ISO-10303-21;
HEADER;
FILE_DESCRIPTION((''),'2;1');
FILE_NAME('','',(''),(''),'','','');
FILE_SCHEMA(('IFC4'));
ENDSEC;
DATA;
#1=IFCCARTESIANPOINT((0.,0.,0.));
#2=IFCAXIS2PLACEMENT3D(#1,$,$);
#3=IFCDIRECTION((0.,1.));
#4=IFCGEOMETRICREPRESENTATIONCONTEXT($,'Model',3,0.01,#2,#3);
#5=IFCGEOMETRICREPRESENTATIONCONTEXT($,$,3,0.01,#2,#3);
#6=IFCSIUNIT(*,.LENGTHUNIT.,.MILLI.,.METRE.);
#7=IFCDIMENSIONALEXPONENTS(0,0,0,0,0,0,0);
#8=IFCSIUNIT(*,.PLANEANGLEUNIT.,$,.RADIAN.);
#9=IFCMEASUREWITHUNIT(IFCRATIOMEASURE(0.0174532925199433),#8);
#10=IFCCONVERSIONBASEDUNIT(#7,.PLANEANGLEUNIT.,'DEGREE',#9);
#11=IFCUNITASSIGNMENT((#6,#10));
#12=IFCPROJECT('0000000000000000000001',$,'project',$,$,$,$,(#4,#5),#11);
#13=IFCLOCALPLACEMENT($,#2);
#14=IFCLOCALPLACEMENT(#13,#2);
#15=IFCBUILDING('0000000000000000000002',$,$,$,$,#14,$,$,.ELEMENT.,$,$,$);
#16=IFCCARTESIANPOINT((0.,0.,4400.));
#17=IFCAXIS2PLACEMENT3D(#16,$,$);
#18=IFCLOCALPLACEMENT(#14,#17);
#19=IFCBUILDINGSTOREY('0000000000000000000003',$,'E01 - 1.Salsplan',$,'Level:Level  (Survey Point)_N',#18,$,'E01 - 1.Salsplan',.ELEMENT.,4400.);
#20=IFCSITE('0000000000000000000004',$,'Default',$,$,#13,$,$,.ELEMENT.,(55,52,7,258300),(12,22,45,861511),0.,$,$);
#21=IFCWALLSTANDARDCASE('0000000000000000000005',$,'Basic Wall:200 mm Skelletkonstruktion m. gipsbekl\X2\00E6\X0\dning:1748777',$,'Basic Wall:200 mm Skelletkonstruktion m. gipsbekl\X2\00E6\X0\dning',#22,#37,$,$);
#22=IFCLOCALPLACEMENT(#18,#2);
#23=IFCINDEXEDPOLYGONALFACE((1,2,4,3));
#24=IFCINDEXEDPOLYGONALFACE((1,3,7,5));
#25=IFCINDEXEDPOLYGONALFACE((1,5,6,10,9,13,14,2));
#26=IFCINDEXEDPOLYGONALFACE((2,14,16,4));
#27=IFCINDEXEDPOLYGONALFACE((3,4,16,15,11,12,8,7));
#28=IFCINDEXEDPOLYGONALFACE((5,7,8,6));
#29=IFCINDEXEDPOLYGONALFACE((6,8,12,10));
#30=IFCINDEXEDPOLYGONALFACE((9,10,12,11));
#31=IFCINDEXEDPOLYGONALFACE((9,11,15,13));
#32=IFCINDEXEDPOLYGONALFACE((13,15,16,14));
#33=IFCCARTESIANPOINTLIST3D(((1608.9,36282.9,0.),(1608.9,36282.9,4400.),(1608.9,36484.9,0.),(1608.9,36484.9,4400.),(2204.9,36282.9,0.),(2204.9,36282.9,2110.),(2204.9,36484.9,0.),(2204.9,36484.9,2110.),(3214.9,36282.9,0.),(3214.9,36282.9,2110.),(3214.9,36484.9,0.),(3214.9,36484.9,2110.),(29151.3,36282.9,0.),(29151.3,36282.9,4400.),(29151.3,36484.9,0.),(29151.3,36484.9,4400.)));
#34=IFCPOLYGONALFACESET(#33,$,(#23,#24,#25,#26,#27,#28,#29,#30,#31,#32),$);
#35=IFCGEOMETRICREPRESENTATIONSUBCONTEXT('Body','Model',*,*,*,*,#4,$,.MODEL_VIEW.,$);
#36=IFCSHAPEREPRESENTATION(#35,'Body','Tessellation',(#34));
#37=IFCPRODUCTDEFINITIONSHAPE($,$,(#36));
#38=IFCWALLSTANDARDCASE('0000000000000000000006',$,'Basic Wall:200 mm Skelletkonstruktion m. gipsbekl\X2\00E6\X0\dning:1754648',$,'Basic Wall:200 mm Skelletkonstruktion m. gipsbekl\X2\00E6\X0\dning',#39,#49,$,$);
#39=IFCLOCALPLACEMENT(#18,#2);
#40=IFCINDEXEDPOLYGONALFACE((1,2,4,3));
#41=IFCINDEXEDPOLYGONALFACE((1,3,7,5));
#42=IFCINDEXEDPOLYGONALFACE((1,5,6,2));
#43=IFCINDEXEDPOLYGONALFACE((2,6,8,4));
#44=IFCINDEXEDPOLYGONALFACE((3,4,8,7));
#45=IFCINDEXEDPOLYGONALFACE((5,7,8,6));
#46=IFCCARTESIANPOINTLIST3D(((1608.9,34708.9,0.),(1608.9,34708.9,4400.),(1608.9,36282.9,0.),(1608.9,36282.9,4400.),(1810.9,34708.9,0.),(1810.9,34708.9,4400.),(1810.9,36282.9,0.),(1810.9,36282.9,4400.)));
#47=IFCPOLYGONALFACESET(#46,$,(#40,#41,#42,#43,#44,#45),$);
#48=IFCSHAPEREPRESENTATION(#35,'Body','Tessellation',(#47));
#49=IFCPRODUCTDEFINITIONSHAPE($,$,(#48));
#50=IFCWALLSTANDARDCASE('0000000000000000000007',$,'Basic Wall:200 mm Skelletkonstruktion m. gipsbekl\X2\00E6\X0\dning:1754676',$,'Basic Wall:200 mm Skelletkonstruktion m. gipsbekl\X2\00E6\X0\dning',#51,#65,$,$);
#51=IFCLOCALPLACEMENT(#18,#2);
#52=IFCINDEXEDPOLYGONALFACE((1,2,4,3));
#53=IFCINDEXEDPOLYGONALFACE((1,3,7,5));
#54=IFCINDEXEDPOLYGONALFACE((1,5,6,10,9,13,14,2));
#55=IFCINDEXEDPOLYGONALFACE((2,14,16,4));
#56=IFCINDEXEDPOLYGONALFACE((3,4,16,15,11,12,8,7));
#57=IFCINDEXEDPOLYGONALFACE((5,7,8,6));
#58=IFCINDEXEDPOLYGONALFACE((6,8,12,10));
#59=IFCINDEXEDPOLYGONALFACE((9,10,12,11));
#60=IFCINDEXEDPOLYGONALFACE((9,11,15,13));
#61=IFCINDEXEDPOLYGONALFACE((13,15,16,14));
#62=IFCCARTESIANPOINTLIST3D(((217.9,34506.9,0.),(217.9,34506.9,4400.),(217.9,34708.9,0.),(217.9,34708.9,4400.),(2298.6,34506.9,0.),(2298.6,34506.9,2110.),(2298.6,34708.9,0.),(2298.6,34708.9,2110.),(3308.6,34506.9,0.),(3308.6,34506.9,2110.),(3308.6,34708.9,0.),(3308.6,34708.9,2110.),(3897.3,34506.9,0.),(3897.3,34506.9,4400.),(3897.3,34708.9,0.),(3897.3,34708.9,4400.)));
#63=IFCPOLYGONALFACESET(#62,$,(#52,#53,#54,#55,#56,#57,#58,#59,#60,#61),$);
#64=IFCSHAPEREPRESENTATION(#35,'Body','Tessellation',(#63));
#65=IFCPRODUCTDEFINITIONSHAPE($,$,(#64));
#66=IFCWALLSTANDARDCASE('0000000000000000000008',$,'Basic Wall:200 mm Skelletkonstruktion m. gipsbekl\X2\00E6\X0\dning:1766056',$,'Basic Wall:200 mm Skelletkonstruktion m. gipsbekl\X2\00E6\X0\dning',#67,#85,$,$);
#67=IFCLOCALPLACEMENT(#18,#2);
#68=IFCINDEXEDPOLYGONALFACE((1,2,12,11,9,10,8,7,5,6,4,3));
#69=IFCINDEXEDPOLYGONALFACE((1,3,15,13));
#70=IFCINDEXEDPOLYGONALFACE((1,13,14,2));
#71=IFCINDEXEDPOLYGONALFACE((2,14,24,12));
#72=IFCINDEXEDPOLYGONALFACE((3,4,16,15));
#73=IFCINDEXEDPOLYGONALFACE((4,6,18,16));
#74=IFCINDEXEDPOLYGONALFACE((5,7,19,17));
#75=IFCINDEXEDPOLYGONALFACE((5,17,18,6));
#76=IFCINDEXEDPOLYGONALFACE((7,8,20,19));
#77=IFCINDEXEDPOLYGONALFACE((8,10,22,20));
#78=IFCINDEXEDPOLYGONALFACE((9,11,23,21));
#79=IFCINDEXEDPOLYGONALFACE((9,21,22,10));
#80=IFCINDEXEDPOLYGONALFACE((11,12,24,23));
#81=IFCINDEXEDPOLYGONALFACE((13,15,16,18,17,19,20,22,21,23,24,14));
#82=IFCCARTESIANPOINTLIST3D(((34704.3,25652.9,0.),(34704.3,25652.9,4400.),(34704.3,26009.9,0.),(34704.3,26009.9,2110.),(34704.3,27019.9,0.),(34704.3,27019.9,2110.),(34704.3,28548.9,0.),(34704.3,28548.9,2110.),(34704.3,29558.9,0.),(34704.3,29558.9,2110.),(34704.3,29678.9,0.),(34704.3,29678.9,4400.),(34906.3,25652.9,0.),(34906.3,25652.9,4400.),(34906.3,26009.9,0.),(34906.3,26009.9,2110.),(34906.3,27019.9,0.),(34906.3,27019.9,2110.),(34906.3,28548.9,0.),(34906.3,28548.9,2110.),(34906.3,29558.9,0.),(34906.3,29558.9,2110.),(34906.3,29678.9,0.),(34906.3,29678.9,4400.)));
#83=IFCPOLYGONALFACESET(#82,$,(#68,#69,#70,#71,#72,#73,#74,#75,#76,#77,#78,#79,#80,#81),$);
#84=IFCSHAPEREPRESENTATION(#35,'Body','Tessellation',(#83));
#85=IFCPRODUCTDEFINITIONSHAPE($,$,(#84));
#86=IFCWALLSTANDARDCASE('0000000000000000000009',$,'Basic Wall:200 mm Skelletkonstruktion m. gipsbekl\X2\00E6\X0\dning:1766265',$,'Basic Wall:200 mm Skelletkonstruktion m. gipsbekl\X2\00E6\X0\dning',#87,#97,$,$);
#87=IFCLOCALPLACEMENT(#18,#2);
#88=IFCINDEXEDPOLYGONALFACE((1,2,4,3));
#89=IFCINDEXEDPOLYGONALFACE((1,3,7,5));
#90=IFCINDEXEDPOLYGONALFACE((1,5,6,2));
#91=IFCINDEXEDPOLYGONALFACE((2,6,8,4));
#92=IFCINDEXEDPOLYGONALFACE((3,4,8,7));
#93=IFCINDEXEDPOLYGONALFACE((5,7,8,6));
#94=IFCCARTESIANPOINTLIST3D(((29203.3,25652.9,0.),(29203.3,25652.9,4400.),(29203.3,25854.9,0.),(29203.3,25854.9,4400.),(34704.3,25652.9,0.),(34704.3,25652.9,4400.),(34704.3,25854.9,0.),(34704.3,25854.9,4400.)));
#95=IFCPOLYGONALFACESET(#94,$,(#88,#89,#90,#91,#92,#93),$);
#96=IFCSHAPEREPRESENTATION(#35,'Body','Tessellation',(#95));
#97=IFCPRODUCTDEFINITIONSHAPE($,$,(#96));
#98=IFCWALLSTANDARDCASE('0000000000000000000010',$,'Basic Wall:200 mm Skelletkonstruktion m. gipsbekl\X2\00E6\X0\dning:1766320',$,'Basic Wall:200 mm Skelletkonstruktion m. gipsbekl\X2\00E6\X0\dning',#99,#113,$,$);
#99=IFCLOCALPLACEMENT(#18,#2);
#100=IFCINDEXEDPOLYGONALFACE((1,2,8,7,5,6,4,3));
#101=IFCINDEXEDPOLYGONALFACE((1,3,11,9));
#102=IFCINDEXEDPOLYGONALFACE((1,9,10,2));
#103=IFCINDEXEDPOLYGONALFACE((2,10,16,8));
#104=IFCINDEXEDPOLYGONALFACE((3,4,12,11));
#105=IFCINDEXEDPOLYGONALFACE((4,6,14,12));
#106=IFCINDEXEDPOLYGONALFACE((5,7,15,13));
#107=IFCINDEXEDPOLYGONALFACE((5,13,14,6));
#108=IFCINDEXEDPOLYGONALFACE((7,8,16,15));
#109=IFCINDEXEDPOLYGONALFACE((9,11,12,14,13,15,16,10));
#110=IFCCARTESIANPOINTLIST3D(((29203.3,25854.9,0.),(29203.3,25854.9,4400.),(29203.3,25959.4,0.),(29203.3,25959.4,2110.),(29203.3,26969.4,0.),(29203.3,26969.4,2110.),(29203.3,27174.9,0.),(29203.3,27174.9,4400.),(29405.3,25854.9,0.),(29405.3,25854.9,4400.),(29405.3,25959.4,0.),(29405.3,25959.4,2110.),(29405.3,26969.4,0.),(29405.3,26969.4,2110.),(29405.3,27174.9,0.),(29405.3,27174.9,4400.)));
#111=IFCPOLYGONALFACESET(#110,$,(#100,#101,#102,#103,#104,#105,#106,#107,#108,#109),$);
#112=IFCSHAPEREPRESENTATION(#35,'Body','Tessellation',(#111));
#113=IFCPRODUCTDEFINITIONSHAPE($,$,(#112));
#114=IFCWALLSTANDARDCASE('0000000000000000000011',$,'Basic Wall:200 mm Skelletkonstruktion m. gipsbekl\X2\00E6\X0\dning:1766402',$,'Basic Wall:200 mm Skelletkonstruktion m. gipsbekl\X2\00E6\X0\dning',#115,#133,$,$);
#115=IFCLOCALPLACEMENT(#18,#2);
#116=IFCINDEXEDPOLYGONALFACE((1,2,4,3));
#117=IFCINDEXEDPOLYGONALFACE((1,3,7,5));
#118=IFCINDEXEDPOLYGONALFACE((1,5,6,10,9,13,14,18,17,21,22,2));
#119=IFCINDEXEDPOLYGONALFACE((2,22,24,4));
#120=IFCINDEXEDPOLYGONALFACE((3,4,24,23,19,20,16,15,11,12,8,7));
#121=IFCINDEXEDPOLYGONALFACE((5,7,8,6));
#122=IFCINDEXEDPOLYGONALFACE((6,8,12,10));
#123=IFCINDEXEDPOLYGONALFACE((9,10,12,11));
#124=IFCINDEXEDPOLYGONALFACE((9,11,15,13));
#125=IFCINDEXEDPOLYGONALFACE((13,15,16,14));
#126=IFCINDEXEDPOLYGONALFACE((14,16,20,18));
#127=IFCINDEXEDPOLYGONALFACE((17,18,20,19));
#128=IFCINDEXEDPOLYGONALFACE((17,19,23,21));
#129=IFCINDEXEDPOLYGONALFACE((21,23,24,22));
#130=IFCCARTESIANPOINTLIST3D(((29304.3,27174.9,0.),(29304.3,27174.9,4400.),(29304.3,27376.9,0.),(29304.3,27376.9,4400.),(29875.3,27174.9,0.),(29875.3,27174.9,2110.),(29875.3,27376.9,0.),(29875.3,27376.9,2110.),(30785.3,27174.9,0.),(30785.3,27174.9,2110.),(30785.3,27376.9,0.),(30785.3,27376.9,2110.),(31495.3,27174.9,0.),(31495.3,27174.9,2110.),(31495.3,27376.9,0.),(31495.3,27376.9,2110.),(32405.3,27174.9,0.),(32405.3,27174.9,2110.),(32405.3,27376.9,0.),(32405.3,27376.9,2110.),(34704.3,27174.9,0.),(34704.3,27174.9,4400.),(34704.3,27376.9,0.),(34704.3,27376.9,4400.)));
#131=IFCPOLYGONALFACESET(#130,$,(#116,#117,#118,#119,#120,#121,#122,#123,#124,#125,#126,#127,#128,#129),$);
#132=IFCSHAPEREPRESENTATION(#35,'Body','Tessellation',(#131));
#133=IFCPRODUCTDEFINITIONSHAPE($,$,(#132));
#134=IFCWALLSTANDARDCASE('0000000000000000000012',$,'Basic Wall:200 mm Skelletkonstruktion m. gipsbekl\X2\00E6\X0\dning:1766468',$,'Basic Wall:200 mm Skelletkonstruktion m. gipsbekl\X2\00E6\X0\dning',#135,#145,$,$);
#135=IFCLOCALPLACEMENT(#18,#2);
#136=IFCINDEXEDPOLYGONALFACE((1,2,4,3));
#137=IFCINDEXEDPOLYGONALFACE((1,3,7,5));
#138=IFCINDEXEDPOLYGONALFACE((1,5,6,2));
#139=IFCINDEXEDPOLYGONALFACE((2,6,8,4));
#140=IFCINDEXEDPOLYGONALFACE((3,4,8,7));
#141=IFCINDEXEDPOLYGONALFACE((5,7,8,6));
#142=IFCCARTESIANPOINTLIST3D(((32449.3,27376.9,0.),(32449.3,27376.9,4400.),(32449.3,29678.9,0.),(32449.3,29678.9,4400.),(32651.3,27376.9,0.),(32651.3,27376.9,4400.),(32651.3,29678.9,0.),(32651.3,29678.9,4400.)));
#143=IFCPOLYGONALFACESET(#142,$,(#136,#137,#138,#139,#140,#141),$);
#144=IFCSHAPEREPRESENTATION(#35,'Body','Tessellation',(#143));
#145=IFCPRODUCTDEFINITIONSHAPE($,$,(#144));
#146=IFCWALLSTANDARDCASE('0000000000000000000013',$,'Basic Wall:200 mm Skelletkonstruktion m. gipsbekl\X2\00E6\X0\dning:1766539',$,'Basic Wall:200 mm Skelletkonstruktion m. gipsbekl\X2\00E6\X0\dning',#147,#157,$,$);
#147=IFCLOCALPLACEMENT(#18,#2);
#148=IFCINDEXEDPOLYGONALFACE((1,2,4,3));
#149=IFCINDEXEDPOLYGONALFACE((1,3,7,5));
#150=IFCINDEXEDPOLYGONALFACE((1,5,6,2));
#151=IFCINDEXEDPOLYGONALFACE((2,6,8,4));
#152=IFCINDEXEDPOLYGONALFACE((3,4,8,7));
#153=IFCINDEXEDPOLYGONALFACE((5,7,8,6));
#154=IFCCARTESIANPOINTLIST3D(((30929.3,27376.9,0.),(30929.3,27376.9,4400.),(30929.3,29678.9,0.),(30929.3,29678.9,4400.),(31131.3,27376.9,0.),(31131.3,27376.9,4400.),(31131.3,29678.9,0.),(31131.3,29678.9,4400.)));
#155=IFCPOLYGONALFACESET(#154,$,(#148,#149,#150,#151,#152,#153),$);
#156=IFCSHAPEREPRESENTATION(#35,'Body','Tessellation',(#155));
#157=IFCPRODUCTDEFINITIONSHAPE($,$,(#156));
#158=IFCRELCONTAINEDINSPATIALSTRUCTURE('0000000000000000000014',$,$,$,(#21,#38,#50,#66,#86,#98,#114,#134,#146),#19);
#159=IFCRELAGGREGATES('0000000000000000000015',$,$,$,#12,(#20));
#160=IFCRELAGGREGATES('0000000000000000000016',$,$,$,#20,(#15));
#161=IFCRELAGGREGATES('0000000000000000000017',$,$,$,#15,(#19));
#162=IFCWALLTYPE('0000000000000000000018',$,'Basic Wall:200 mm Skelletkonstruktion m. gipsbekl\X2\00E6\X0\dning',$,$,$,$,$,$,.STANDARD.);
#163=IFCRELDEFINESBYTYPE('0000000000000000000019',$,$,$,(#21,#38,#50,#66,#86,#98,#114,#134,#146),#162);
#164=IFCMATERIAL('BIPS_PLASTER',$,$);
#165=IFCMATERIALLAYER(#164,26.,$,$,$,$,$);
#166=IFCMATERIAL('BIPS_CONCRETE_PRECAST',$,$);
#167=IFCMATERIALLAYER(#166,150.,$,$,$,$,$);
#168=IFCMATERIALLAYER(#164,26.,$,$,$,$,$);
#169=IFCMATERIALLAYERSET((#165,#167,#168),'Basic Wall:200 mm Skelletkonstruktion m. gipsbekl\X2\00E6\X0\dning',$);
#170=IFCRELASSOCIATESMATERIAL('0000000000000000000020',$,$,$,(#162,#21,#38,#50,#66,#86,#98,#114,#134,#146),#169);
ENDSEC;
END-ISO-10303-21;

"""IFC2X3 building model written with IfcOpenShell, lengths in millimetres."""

from ifc_helpers import new_model, entity, si_unit, converted_unit, direction, frame, frame_2d, origin, place, context, subcontext, project, spatial, rectangle, extrude, material, layer, layer_set, layer_usage, type_object, element, save


model = new_model("IFC2X3")

# Units and contexts
model_context = context("Model", 3, precision=0.01, world=origin(), true_north=direction((0.0, 1.0)))
context_of_model = context(None, 3, precision=0.01, world=origin(), true_north=direction((0.0, 1.0)))
body_context = subcontext(model_context, "Body", "Model", "MODEL_VIEW")
ifc_project = project(units=[si_unit("LENGTHUNIT", "METRE", prefix="MILLI"), converted_unit("PLANEANGLEUNIT", "DEGREE", entity("IfcRatioMeasure", 0.0174532925199433), si_unit("PLANEANGLEUNIT", "RADIAN"), dimensions=[0, 0, 0, 0, 0, 0, 0])], contexts=[model_context, context_of_model])

# Site, building, storey
site_placement = place(None, origin())
site = spatial("IfcSite", under=ifc_project, at=site_placement, Name="Default", CompositionType="ELEMENT", RefLatitude=(55, 52, 7, 258300), RefLongitude=(12, 22, 45, 861511), RefElevation=0.0)
building_placement = place(site_placement, origin())
building = spatial("IfcBuilding", under=site, at=building_placement, CompositionType="ELEMENT")
storey_placement = place(building_placement, frame((0.0, 0.0, 4400.0)))
storey = spatial("IfcBuildingStorey", under=building, at=storey_placement, Name="E01 - 1.Salsplan", ObjectType="Level:Level  (Survey Point)_N", LongName="E01 - 1.Salsplan", CompositionType="ELEMENT", Elevation=4400.0)

# Shared definitions
ifc_material_1 = material(Name="BIPS_CONCRETE_PRECAST")

# Wall, opening
ifc_material_2 = material(Name="BIPS_PLASTER")
ifc_layer_1 = layer(ifc_material_2, 26.0)
ifc_layer_2 = layer(ifc_material_1, 150.0)
ifc_layer_3 = layer(ifc_material_2, 26.0)
ifc_layer_set_1 = layer_set([ifc_layer_1, ifc_layer_2, ifc_layer_3], Name="Basic Wall:200 mm Skelletkonstruktion m. gipsbeklædning")
ifc_layer_usage_1 = layer_usage(ifc_layer_set_1, "AXIS2", "NEGATIVE", 101.0)
wall_type_1 = type_object("IfcWallType", Name="Basic Wall:200 mm Skelletkonstruktion m. gipsbeklædning", PredefinedType="STANDARD", material=ifc_layer_set_1)
wall_1_placement = place(storey_placement, frame((29151.3, 36383.9, 0.0), z_axis=(0.0, 0.0, 1.0), x_axis=(-1.0, 0.0, 0.0)))
wall_1 = element("IfcWallStandardCase", 1, at=wall_1_placement, inside=storey, type_object=wall_type_1, material=ifc_layer_usage_1, Name="Basic Wall:200 mm Skelletkonstruktion m. gipsbeklædning:1748777", ObjectType="Basic Wall:200 mm Skelletkonstruktion m. gipsbeklædning", context=body_context, shape_type="SweptSolid", body=[
    extrude(rectangle(XDim=27542.4, YDim=202.0, at=frame_2d((13771.2, 0.0), x_axis=(-1.0, 0.0))), origin(), (0.0, 0.0, 1.0), 4400.0),
])
opening_1_placement = place(wall_1_placement, frame((26946.4, 101.0, 0.0)))
element("IfcOpeningElement", 2, at=opening_1_placement, cuts=wall_1, ObjectType="Opening", context=body_context, shape_type="SweptSolid", body=[
    extrude(rectangle(XDim=2110.0, YDim=1010.0, at=frame_2d((1055.0, 505.0), x_axis=(1.0, 0.0))), frame((0.0, 0.0, 0.0), z_axis=(0.0, -1.0, 0.0), x_axis=(0.0, 0.0, 1.0)), (0.0, 0.0, 1.0), 202.0),
])

# Wall
ifc_layer_usage_2 = layer_usage(ifc_layer_set_1, "AXIS2", "NEGATIVE", 101.0)
wall_2_placement = place(storey_placement, frame((1709.9, 36282.9, 0.0), z_axis=(0.0, 0.0, 1.0), x_axis=(0.0, -1.0, 0.0)))
element("IfcWallStandardCase", 3, at=wall_2_placement, inside=storey, type_object=wall_type_1, material=ifc_layer_usage_2, Name="Basic Wall:200 mm Skelletkonstruktion m. gipsbeklædning:1754648", ObjectType="Basic Wall:200 mm Skelletkonstruktion m. gipsbeklædning", context=body_context, shape_type="SweptSolid", body=[
    extrude(rectangle(XDim=1574.0, YDim=202.0, at=frame_2d((787.0, 0.0), x_axis=(-1.0, 0.0))), origin(), (0.0, 0.0, 1.0), 4400.0),
])

# Wall, opening
ifc_layer_usage_3 = layer_usage(ifc_layer_set_1, "AXIS2", "NEGATIVE", 101.0)
wall_3_placement = place(storey_placement, frame((217.9, 34607.9, 0.0)))
wall_3 = element("IfcWallStandardCase", 4, at=wall_3_placement, inside=storey, type_object=wall_type_1, material=ifc_layer_usage_3, Name="Basic Wall:200 mm Skelletkonstruktion m. gipsbeklædning:1754676", ObjectType="Basic Wall:200 mm Skelletkonstruktion m. gipsbeklædning", context=body_context, shape_type="SweptSolid", body=[
    extrude(rectangle(XDim=3679.4, YDim=202.0, at=frame_2d((1839.7, 0.0), x_axis=(-1.0, 0.0))), origin(), (0.0, 0.0, 1.0), 4400.0),
])
opening_2_placement = place(wall_3_placement, frame((3090.7, 101.0, 0.0)))
element("IfcOpeningElement", 5, at=opening_2_placement, cuts=wall_3, ObjectType="Opening", context=body_context, shape_type="SweptSolid", body=[
    extrude(rectangle(XDim=2110.0, YDim=1010.0, at=frame_2d((1055.0, 505.0), x_axis=(1.0, 0.0))), frame((0.0, 0.0, 0.0), z_axis=(0.0, -1.0, 0.0), x_axis=(0.0, 0.0, 1.0)), (0.0, 0.0, 1.0), 202.0),
])

# Wall, openings
ifc_layer_usage_4 = layer_usage(ifc_layer_set_1, "AXIS2", "NEGATIVE", 101.0)
wall_4_placement = place(storey_placement, frame((34805.3, 29678.9, 0.0), z_axis=(0.0, 0.0, 1.0), x_axis=(0.0, -1.0, 0.0)))
wall_4 = element("IfcWallStandardCase", 6, at=wall_4_placement, inside=storey, type_object=wall_type_1, material=ifc_layer_usage_4, Name="Basic Wall:200 mm Skelletkonstruktion m. gipsbeklædning:1766056", ObjectType="Basic Wall:200 mm Skelletkonstruktion m. gipsbeklædning", context=body_context, shape_type="SweptSolid", body=[
    extrude(rectangle(XDim=4026.0, YDim=202.0, at=frame_2d((2013.0, 0.0), x_axis=(-1.0, 0.0))), origin(), (0.0, 0.0, 1.0), 4400.0),
])
opening_3_placement = place(wall_4_placement, frame((1130.0, 101.0, 0.0)))
element("IfcOpeningElement", 7, at=opening_3_placement, cuts=wall_4, ObjectType="Opening", context=body_context, shape_type="SweptSolid", body=[
    extrude(rectangle(XDim=2110.0, YDim=1010.0, at=frame_2d((1055.0, 505.0), x_axis=(1.0, 0.0))), frame((0.0, 0.0, 0.0), z_axis=(0.0, -1.0, 0.0), x_axis=(0.0, 0.0, 1.0)), (0.0, 0.0, 1.0), 202.0),
])
opening_4_placement = place(wall_4_placement, frame((3669.0, 101.0, 0.0)))
element("IfcOpeningElement", 8, at=opening_4_placement, cuts=wall_4, ObjectType="Opening", context=body_context, shape_type="SweptSolid", body=[
    extrude(rectangle(XDim=2110.0, YDim=1010.0, at=frame_2d((1055.0, 505.0), x_axis=(1.0, 0.0))), frame((0.0, 0.0, 0.0), z_axis=(0.0, -1.0, 0.0), x_axis=(0.0, 0.0, 1.0)), (0.0, 0.0, 1.0), 202.0),
])

# Wall
ifc_layer_usage_5 = layer_usage(ifc_layer_set_1, "AXIS2", "NEGATIVE", 101.0)
wall_5_placement = place(storey_placement, frame((34704.3, 25753.9, 0.0), z_axis=(0.0, 0.0, 1.0), x_axis=(-1.0, 0.0, 0.0)))
element("IfcWallStandardCase", 9, at=wall_5_placement, inside=storey, type_object=wall_type_1, material=ifc_layer_usage_5, Name="Basic Wall:200 mm Skelletkonstruktion m. gipsbeklædning:1766265", ObjectType="Basic Wall:200 mm Skelletkonstruktion m. gipsbeklædning", context=body_context, shape_type="SweptSolid", body=[
    extrude(rectangle(XDim=5501.0, YDim=202.0, at=frame_2d((2750.5, 0.0), x_axis=(-1.0, 0.0))), origin(), (0.0, 0.0, 1.0), 4400.0),
])

# Wall, opening
ifc_layer_usage_6 = layer_usage(ifc_layer_set_1, "AXIS2", "NEGATIVE", 101.0)
wall_6_placement = place(storey_placement, frame((29304.3, 25854.9, 0.0), z_axis=(0.0, 0.0, 1.0), x_axis=(0.0, 1.0, 0.0)))
wall_6 = element("IfcWallStandardCase", 10, at=wall_6_placement, inside=storey, type_object=wall_type_1, material=ifc_layer_usage_6, Name="Basic Wall:200 mm Skelletkonstruktion m. gipsbeklædning:1766320", ObjectType="Basic Wall:200 mm Skelletkonstruktion m. gipsbeklædning", context=body_context, shape_type="SweptSolid", body=[
    extrude(rectangle(XDim=1320.0, YDim=202.0, at=frame_2d((660.0, 0.0), x_axis=(-1.0, 0.0))), origin(), (0.0, 0.0, 1.0), 4400.0),
])
opening_5_placement = place(wall_6_placement, frame((1114.5, 101.0, 0.0)))
element("IfcOpeningElement", 11, at=opening_5_placement, cuts=wall_6, ObjectType="Opening", context=body_context, shape_type="SweptSolid", body=[
    extrude(rectangle(XDim=2110.0, YDim=1010.0, at=frame_2d((1055.0, 505.0), x_axis=(1.0, 0.0))), frame((0.0, 0.0, 0.0), z_axis=(0.0, -1.0, 0.0), x_axis=(0.0, 0.0, 1.0)), (0.0, 0.0, 1.0), 202.0),
])

# Wall, openings
ifc_layer_usage_7 = layer_usage(ifc_layer_set_1, "AXIS2", "NEGATIVE", 101.0)
wall_7_placement = place(storey_placement, frame((29304.3, 27275.9, 0.0)))
wall_7 = element("IfcWallStandardCase", 12, at=wall_7_placement, inside=storey, type_object=wall_type_1, material=ifc_layer_usage_7, Name="Basic Wall:200 mm Skelletkonstruktion m. gipsbeklædning:1766402", ObjectType="Basic Wall:200 mm Skelletkonstruktion m. gipsbeklædning", context=body_context, shape_type="SweptSolid", body=[
    extrude(rectangle(XDim=5400.0, YDim=202.0, at=frame_2d((2700.0, 0.0), x_axis=(-1.0, 0.0))), origin(), (0.0, 0.0, 1.0), 4400.0),
])
opening_6_placement = place(wall_7_placement, frame((571.0, -101.0, 0.0)))
element("IfcOpeningElement", 13, at=opening_6_placement, cuts=wall_7, ObjectType="Opening", context=body_context, shape_type="SweptSolid", body=[
    extrude(rectangle(XDim=2110.0, YDim=910.0, at=frame_2d((1055.0, 455.0), x_axis=(1.0, 0.0))), frame((0.0, 0.0, 0.0), z_axis=(0.0, 1.0, 0.0), x_axis=(0.0, 0.0, 1.0)), (0.0, 0.0, 1.0), 202.0),
])
opening_7_placement = place(wall_7_placement, frame((2191.0, -101.0, 0.0)))
element("IfcOpeningElement", 14, at=opening_7_placement, cuts=wall_7, ObjectType="Opening", context=body_context, shape_type="SweptSolid", body=[
    extrude(rectangle(XDim=2110.0, YDim=910.0, at=frame_2d((1055.0, 455.0), x_axis=(1.0, 0.0))), frame((0.0, 0.0, 0.0), z_axis=(0.0, 1.0, 0.0), x_axis=(0.0, 0.0, 1.0)), (0.0, 0.0, 1.0), 202.0),
])

# Walls
ifc_layer_usage_8 = layer_usage(ifc_layer_set_1, "AXIS2", "NEGATIVE", 101.0)
wall_8_placement = place(storey_placement, frame((32550.3, 27376.9, 0.0), z_axis=(0.0, 0.0, 1.0), x_axis=(0.0, 1.0, 0.0)))
element("IfcWallStandardCase", 15, at=wall_8_placement, inside=storey, type_object=wall_type_1, material=ifc_layer_usage_8, Name="Basic Wall:200 mm Skelletkonstruktion m. gipsbeklædning:1766468", ObjectType="Basic Wall:200 mm Skelletkonstruktion m. gipsbeklædning", context=body_context, shape_type="SweptSolid", body=[
    extrude(rectangle(XDim=2302.0, YDim=202.0, at=frame_2d((1151.0, 0.0), x_axis=(-1.0, 0.0))), origin(), (0.0, 0.0, 1.0), 4400.0),
])
ifc_layer_usage_9 = layer_usage(ifc_layer_set_1, "AXIS2", "NEGATIVE", 101.0)
wall_9_placement = place(storey_placement, frame((31030.3, 27376.9, 0.0), z_axis=(0.0, 0.0, 1.0), x_axis=(0.0, 1.0, 0.0)))
element("IfcWallStandardCase", 16, at=wall_9_placement, inside=storey, type_object=wall_type_1, material=ifc_layer_usage_9, Name="Basic Wall:200 mm Skelletkonstruktion m. gipsbeklædning:1766539", ObjectType="Basic Wall:200 mm Skelletkonstruktion m. gipsbeklædning", context=body_context, shape_type="SweptSolid", body=[
    extrude(rectangle(XDim=2302.0, YDim=202.0, at=frame_2d((1151.0, 0.0), x_axis=(-1.0, 0.0))), origin(), (0.0, 0.0, 1.0), 4400.0),
])

save(model, "model.ifc")
